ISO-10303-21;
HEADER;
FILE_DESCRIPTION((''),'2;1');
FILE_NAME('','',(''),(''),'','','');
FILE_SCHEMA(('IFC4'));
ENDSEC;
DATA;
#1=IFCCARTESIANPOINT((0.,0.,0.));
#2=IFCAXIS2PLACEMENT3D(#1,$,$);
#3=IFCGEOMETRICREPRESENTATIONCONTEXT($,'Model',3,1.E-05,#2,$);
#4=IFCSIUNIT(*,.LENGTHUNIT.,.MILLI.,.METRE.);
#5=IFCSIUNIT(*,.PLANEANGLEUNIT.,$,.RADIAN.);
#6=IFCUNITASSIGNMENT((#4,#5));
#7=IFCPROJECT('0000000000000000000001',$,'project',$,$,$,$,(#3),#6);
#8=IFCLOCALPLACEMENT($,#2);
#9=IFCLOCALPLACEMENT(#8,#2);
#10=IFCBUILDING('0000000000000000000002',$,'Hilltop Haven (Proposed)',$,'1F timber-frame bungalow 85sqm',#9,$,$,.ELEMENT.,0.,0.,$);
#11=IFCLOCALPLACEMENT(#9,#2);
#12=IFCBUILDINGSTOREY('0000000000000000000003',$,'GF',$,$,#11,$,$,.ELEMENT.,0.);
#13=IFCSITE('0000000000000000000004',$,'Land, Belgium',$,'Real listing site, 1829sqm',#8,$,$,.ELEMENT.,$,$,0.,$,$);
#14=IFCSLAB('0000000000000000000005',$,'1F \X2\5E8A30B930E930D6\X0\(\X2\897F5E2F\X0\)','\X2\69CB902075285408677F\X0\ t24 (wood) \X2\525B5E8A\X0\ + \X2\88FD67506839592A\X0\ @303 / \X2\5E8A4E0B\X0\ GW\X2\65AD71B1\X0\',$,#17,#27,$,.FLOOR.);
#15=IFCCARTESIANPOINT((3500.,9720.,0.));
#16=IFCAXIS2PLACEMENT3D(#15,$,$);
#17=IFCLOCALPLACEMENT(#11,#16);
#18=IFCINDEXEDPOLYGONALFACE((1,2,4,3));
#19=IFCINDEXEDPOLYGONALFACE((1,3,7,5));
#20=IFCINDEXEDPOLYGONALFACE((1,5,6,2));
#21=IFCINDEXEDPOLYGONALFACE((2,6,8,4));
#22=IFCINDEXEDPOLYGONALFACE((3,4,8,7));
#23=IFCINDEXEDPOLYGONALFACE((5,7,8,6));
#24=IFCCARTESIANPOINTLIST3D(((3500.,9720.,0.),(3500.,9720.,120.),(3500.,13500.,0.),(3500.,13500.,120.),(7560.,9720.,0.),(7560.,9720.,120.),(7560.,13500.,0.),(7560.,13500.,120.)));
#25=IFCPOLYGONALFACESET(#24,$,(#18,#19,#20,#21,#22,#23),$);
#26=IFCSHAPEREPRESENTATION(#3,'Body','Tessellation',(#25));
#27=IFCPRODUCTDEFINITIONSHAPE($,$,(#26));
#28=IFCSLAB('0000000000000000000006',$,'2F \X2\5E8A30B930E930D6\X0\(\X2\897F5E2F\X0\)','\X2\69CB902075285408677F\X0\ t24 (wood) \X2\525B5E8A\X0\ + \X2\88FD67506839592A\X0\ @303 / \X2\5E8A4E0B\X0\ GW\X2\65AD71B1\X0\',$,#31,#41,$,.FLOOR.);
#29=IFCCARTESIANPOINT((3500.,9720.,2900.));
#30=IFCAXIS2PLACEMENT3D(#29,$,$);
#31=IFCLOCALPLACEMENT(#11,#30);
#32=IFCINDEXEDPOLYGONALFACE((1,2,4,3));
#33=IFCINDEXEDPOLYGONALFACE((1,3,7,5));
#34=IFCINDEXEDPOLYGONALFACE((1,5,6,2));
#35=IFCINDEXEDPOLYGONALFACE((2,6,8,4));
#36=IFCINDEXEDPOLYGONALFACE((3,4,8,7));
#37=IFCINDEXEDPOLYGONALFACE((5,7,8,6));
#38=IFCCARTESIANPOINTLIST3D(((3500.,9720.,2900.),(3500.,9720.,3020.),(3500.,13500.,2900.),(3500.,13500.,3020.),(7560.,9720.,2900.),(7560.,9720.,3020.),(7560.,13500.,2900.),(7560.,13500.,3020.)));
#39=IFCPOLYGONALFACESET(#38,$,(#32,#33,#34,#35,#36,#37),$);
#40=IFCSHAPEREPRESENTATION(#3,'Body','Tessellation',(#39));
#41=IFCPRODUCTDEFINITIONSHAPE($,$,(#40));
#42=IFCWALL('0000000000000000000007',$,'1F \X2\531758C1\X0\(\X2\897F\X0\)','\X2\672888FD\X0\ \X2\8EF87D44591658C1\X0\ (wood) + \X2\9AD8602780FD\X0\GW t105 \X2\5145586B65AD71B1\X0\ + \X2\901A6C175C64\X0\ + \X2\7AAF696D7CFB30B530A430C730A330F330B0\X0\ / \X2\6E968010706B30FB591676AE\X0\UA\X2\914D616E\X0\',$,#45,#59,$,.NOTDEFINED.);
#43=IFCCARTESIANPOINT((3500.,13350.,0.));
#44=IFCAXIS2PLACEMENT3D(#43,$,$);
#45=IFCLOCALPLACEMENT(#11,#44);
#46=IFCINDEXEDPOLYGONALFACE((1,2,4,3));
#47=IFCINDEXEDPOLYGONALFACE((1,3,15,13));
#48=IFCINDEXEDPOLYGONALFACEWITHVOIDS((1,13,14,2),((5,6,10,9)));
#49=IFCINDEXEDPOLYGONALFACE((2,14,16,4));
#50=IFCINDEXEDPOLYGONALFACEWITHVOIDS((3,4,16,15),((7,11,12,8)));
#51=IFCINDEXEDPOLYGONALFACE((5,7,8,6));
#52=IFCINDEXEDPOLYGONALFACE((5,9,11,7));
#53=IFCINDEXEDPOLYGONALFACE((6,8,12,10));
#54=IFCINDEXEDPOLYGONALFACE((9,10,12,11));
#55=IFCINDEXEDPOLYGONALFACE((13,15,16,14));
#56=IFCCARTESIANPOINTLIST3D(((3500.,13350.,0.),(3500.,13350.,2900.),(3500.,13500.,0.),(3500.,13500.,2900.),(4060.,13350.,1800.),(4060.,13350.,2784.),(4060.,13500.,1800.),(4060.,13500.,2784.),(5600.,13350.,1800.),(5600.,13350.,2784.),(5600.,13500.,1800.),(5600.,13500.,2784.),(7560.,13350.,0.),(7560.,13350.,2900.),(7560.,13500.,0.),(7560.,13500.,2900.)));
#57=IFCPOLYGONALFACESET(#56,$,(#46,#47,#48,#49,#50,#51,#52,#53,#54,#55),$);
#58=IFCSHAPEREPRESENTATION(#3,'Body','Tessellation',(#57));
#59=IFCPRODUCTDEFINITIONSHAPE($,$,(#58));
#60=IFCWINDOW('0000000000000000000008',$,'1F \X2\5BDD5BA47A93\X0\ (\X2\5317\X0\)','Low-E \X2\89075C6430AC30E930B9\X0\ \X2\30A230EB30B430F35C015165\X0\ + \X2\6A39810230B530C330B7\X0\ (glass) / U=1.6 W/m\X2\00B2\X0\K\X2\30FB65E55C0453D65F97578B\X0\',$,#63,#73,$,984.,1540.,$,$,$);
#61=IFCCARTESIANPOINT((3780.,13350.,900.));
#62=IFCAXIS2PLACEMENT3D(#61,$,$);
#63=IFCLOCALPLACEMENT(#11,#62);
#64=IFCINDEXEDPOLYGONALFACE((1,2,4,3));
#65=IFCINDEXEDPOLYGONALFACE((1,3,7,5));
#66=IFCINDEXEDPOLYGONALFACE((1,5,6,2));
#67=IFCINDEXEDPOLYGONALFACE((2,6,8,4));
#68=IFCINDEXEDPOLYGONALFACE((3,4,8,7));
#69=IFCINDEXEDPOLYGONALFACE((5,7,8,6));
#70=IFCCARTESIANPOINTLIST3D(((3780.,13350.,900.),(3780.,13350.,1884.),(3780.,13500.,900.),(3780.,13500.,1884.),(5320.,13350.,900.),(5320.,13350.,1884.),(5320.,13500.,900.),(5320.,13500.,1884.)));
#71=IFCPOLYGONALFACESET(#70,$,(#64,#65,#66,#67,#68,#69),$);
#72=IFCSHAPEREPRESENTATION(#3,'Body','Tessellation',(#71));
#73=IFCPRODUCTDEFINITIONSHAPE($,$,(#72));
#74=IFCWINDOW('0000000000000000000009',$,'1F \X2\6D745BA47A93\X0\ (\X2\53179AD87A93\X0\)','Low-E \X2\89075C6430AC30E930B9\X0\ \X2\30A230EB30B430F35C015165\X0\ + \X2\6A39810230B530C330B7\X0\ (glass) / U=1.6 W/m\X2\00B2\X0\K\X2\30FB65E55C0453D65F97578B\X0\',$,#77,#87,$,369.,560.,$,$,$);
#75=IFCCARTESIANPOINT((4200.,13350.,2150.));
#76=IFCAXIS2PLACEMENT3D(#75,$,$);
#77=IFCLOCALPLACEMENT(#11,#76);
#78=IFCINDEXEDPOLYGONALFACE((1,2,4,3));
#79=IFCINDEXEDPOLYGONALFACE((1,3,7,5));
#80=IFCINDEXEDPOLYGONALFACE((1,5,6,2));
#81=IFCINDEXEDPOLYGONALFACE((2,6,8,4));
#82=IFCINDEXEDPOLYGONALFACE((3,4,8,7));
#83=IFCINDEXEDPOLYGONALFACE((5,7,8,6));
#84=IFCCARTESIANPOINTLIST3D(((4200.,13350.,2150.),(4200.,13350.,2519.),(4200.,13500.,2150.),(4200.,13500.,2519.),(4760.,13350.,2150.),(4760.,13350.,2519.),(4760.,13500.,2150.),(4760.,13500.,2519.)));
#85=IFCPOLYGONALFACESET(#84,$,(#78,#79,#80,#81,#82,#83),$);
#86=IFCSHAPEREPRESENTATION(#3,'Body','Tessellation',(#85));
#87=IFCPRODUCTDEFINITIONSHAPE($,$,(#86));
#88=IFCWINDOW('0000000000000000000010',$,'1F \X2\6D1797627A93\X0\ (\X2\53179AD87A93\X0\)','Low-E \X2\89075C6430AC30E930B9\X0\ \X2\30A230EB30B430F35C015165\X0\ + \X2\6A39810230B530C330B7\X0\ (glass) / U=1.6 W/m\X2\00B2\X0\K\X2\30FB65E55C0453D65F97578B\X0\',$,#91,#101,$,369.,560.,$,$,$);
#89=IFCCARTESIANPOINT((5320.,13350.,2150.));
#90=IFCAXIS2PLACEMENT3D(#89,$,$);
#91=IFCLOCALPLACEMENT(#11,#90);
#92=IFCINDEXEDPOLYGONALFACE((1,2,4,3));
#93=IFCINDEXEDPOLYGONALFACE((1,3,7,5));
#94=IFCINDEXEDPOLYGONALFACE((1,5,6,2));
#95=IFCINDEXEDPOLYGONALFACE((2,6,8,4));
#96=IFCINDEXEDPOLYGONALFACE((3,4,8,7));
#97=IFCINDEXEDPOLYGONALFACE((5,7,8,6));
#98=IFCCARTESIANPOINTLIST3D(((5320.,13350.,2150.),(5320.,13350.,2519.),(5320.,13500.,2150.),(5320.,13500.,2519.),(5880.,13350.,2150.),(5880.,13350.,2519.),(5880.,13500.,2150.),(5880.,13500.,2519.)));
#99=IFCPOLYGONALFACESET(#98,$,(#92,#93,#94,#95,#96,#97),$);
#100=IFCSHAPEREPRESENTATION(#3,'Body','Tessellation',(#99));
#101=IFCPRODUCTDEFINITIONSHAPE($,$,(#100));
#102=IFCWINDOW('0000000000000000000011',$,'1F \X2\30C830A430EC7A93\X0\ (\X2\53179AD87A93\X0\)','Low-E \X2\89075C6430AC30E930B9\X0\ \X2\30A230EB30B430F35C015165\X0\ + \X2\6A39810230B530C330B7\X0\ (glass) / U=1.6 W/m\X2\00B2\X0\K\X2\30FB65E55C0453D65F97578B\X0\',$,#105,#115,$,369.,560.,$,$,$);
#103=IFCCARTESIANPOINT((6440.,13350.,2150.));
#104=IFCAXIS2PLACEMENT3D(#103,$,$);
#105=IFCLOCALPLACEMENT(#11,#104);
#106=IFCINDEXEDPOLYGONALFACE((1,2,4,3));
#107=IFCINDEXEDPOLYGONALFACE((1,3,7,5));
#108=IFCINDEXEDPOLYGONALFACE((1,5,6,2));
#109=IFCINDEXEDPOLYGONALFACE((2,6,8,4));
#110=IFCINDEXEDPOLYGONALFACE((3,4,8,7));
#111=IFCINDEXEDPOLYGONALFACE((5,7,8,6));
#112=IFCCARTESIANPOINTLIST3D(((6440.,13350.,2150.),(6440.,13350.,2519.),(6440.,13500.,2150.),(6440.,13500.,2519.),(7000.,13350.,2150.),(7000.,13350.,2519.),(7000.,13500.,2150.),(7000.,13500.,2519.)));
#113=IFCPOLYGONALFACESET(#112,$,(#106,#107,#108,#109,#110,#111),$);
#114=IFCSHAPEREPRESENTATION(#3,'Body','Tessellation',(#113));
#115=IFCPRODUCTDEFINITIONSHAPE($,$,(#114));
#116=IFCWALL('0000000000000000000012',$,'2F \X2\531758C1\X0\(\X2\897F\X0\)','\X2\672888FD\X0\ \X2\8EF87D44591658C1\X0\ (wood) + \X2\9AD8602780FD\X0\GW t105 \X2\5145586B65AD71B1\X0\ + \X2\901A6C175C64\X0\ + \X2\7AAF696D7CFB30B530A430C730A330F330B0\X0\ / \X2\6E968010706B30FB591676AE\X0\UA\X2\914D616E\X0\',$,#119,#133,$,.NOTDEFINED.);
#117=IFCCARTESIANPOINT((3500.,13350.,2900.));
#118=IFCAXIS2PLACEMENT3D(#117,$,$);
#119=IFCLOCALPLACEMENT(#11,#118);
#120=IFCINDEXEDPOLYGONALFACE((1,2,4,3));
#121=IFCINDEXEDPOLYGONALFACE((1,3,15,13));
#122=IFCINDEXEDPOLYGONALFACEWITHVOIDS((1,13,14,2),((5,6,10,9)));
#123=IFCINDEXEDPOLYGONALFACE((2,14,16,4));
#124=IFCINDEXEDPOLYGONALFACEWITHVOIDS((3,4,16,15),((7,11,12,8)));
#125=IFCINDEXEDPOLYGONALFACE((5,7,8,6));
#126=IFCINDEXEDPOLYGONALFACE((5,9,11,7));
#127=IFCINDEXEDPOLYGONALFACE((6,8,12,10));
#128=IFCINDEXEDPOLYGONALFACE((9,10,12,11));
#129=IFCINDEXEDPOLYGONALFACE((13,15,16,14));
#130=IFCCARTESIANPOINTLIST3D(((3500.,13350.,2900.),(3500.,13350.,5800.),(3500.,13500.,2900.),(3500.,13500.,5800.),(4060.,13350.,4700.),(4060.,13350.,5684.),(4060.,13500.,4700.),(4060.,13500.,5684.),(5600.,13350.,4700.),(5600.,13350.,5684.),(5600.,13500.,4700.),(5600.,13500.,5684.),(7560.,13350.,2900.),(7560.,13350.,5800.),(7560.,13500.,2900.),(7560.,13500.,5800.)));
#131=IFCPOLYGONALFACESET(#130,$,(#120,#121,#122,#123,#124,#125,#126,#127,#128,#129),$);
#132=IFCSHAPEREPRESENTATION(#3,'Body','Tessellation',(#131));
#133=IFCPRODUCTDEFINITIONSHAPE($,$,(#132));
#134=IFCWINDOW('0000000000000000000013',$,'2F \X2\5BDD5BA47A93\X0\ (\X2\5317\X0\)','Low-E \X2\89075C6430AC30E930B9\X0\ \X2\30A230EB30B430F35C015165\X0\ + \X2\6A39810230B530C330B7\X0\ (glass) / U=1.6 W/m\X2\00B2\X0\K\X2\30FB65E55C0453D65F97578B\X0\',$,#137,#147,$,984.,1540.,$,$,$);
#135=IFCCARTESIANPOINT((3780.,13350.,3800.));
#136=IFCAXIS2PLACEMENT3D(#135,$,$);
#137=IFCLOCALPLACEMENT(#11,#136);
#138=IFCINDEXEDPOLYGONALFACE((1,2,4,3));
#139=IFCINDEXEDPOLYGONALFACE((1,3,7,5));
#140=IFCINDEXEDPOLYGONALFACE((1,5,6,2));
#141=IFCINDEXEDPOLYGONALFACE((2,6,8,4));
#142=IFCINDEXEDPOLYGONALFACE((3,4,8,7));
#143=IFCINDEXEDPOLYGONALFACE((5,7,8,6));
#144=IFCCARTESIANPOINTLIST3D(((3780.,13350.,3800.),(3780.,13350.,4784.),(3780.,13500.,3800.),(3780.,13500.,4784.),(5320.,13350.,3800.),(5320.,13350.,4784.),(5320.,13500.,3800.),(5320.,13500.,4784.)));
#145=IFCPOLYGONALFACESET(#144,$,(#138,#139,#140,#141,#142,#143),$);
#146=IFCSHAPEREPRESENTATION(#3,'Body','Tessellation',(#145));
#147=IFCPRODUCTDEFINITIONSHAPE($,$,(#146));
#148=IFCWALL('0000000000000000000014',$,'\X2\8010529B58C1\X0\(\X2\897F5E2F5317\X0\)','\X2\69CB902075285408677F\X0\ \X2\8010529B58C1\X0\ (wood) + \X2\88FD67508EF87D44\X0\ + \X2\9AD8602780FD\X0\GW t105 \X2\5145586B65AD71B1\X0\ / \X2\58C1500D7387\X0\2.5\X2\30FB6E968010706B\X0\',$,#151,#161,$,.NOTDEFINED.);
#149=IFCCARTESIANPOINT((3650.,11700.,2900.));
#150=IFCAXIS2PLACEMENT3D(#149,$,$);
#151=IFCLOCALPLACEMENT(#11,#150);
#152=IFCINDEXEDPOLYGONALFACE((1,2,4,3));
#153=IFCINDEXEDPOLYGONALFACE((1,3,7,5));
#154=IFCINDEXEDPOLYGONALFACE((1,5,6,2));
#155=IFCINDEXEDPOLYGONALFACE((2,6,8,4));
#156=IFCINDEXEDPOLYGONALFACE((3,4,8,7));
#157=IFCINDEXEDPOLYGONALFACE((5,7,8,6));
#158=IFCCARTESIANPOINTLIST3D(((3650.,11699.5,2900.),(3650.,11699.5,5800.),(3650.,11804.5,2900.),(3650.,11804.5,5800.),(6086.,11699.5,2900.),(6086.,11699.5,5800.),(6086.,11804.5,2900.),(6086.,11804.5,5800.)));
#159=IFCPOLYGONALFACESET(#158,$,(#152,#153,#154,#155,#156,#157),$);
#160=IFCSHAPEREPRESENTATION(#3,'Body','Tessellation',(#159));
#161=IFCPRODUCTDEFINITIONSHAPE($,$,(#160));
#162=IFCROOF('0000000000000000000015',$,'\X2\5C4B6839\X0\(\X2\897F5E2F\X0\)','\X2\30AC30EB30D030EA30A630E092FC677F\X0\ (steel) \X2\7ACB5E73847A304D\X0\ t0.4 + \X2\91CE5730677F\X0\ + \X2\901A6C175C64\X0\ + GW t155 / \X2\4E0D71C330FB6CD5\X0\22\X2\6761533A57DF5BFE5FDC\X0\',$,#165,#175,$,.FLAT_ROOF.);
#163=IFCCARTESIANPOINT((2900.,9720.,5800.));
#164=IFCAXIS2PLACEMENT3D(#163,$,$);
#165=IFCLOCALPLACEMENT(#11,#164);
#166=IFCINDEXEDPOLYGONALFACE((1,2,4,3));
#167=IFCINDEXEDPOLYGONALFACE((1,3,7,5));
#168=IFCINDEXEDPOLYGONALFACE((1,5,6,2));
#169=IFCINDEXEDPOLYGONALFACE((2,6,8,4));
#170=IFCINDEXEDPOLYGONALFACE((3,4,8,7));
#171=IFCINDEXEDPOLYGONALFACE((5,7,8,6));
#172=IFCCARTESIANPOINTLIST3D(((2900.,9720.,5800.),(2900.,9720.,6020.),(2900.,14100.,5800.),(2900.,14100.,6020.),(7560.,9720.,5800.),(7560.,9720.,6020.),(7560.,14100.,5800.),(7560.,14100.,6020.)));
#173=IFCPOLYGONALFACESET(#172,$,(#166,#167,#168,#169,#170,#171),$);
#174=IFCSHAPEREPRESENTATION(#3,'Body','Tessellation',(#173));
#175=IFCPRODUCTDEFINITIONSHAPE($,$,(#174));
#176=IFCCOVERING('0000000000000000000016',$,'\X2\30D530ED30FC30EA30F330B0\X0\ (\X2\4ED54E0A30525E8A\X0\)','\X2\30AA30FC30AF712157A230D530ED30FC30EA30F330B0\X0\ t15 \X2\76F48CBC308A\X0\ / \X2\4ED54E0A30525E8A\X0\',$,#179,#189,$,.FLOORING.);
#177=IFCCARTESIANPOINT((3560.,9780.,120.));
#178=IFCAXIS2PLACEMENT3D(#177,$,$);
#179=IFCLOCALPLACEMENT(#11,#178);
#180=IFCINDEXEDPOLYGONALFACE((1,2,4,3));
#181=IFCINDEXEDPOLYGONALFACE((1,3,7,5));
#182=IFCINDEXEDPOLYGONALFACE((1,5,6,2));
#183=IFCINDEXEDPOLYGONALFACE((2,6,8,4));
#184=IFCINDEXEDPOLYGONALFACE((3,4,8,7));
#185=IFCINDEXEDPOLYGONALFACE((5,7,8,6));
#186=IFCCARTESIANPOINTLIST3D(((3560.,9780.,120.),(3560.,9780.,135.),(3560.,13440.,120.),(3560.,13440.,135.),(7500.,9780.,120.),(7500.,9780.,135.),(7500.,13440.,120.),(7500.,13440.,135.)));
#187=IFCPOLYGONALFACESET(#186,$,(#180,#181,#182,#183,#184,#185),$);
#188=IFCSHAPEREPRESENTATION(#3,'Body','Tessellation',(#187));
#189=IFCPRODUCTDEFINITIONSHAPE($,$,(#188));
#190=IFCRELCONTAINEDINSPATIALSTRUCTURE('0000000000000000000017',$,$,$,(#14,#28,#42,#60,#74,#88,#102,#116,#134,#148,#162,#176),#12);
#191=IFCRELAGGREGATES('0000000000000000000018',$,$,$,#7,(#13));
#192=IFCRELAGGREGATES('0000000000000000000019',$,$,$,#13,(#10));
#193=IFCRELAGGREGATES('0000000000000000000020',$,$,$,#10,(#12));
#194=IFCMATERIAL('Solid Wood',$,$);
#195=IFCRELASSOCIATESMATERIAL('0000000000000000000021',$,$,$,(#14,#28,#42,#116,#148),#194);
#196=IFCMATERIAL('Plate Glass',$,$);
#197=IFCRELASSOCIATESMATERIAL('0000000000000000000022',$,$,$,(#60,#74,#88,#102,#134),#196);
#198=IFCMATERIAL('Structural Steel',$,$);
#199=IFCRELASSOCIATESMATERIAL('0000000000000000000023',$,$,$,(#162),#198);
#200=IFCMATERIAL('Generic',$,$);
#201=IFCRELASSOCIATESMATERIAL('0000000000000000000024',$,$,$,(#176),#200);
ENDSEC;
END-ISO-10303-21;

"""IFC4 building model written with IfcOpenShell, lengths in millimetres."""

from ifc_helpers import new_model, si_unit, frame, frame_2d, origin, place, context, project, spatial, rectangle, extrude, material, element, fill, save


model = new_model("IFC4")

# Units and contexts
model_context = context("Model", 3, precision=1e-05, world=origin())
ifc_project = project(units=[si_unit("LENGTHUNIT", "METRE", prefix="MILLI"), si_unit("PLANEANGLEUNIT", "RADIAN")], contexts=[model_context])

# Site, building, storey
site_placement = place(None, origin())
site = spatial("IfcSite", under=ifc_project, at=site_placement, Name="Land, Belgium", ObjectType="Real listing site, 1829sqm", CompositionType="ELEMENT", RefElevation=0.0)
building_placement = place(site_placement, origin())
building = spatial("IfcBuilding", under=site, at=building_placement, Name="Hilltop Haven (Proposed)", ObjectType="1F timber-frame bungalow 85sqm", CompositionType="ELEMENT", ElevationOfRefHeight=0.0, ElevationOfTerrain=0.0)
storey_placement = place(building_placement, origin())
storey = spatial("IfcBuildingStorey", under=building, at=storey_placement, Name="GF", CompositionType="ELEMENT", Elevation=0.0)

# Slabs
ifc_material_1 = material(Name="Solid Wood")
slab_1_placement = place(storey_placement, frame((3500.0, 9720.0, 0.0)))
element("IfcSlab", 1, at=slab_1_placement, inside=storey, material=ifc_material_1, Name="1F 床スラブ(西帯)", Description="構造用合板 t24 (wood) 剛床 + 製材根太 @303 / 床下 GW断熱", PredefinedType="FLOOR", context=model_context, shape_type="SweptSolid", body=[
    extrude(rectangle(XDim=4060.0, YDim=3780.0, at=frame_2d((2030.0, 1890.0))), frame((3500.0, 9720.0, 0.0)), (0.0, 0.0, 1.0), 120.0),
])
slab_2_placement = place(storey_placement, frame((3500.0, 9720.0, 2900.0)))
element("IfcSlab", 2, at=slab_2_placement, inside=storey, material=ifc_material_1, Name="2F 床スラブ(西帯)", Description="構造用合板 t24 (wood) 剛床 + 製材根太 @303 / 床下 GW断熱", PredefinedType="FLOOR", context=model_context, shape_type="SweptSolid", body=[
    extrude(rectangle(XDim=4060.0, YDim=3780.0, at=frame_2d((2030.0, 1890.0))), frame((3500.0, 9720.0, 2900.0)), (0.0, 0.0, 1.0), 120.0),
])

# Wall, openings, windows
wall_1_placement = place(storey_placement, frame((3500.0, 13350.0, 0.0)))
wall_1 = element("IfcWall", 3, at=wall_1_placement, inside=storey, material=ifc_material_1, Name="1F 北壁(西)", Description="木製 軸組外壁 (wood) + 高性能GW t105 充填断熱 + 通気層 + 窯業系サイディング / 準耐火・外皮UA配慮", PredefinedType="NOTDEFINED", context=model_context, shape_type="SweptSolid", body=[
    extrude(rectangle(XDim=4060.0, YDim=150.0, at=frame_2d((2030.0, 75.0))), frame((3500.0, 13350.0, 0.0)), (0.0, 0.0, 1.0), 2900.0),
])
opening_1_placement = place(storey_placement, frame((3780.0, 13350.0, 900.0)))
opening_1 = element("IfcOpeningElement", 4, at=opening_1_placement, cuts=wall_1, PredefinedType="NOTDEFINED", context=model_context, shape_type="SweptSolid", body=[
    extrude(rectangle(XDim=1540.0, YDim=150.0, at=frame_2d((770.0, 75.0))), frame((3780.0, 13350.0, 900.0)), (0.0, 0.0, 1.0), 984.0),
])
opening_2_placement = place(storey_placement, frame((4200.0, 13350.0, 2150.0)))
opening_2 = element("IfcOpeningElement", 5, at=opening_2_placement, cuts=wall_1, PredefinedType="NOTDEFINED", context=model_context, shape_type="SweptSolid", body=[
    extrude(rectangle(XDim=560.0, YDim=150.0, at=frame_2d((280.0, 75.0))), frame((4200.0, 13350.0, 2150.0)), (0.0, 0.0, 1.0), 369.0),
])
opening_3_placement = place(storey_placement, frame((5320.0, 13350.0, 2150.0)))
opening_3 = element("IfcOpeningElement", 6, at=opening_3_placement, cuts=wall_1, PredefinedType="NOTDEFINED", context=model_context, shape_type="SweptSolid", body=[
    extrude(rectangle(XDim=560.0, YDim=150.0, at=frame_2d((280.0, 75.0))), frame((5320.0, 13350.0, 2150.0)), (0.0, 0.0, 1.0), 369.0),
])
opening_4_placement = place(storey_placement, frame((6440.0, 13350.0, 2150.0)))
opening_4 = element("IfcOpeningElement", 7, at=opening_4_placement, cuts=wall_1, PredefinedType="NOTDEFINED", context=model_context, shape_type="SweptSolid", body=[
    extrude(rectangle(XDim=560.0, YDim=150.0, at=frame_2d((280.0, 75.0))), frame((6440.0, 13350.0, 2150.0)), (0.0, 0.0, 1.0), 369.0),
])
ifc_material_2 = material(Name="Plate Glass")
window_1_placement = place(storey_placement, frame((3780.0, 13350.0, 900.0)))
window_1 = element("IfcWindow", 8, at=window_1_placement, inside=storey, material=ifc_material_2, Name="1F 寝室窓 (北)", Description="Low-E 複層ガラス アルゴン封入 + 樹脂サッシ (glass) / U=1.6 W/m²K・日射取得型", OverallHeight=984.0, OverallWidth=1540.0, context=model_context, shape_type="SweptSolid", body=[
    extrude(rectangle(XDim=1540.0, YDim=150.0, at=frame_2d((770.0, 75.0))), frame((3780.0, 13350.0, 900.0)), (0.0, 0.0, 1.0), 984.0),
])
fill(opening_1, window_1)
window_2_placement = place(storey_placement, frame((4200.0, 13350.0, 2150.0)))
window_2 = element("IfcWindow", 9, at=window_2_placement, inside=storey, material=ifc_material_2, Name="1F 浴室窓 (北高窓)", Description="Low-E 複層ガラス アルゴン封入 + 樹脂サッシ (glass) / U=1.6 W/m²K・日射取得型", OverallHeight=369.0, OverallWidth=560.0, context=model_context, shape_type="SweptSolid", body=[
    extrude(rectangle(XDim=560.0, YDim=150.0, at=frame_2d((280.0, 75.0))), frame((4200.0, 13350.0, 2150.0)), (0.0, 0.0, 1.0), 369.0),
])
fill(opening_2, window_2)
window_3_placement = place(storey_placement, frame((5320.0, 13350.0, 2150.0)))
window_3 = element("IfcWindow", 10, at=window_3_placement, inside=storey, material=ifc_material_2, Name="1F 洗面窓 (北高窓)", Description="Low-E 複層ガラス アルゴン封入 + 樹脂サッシ (glass) / U=1.6 W/m²K・日射取得型", OverallHeight=369.0, OverallWidth=560.0, context=model_context, shape_type="SweptSolid", body=[
    extrude(rectangle(XDim=560.0, YDim=150.0, at=frame_2d((280.0, 75.0))), frame((5320.0, 13350.0, 2150.0)), (0.0, 0.0, 1.0), 369.0),
])
fill(opening_3, window_3)
window_4_placement = place(storey_placement, frame((6440.0, 13350.0, 2150.0)))
window_4 = element("IfcWindow", 11, at=window_4_placement, inside=storey, material=ifc_material_2, Name="1F トイレ窓 (北高窓)", Description="Low-E 複層ガラス アルゴン封入 + 樹脂サッシ (glass) / U=1.6 W/m²K・日射取得型", OverallHeight=369.0, OverallWidth=560.0, context=model_context, shape_type="SweptSolid", body=[
    extrude(rectangle(XDim=560.0, YDim=150.0, at=frame_2d((280.0, 75.0))), frame((6440.0, 13350.0, 2150.0)), (0.0, 0.0, 1.0), 369.0),
])
fill(opening_4, window_4)

# Wall, opening, window
wall_2_placement = place(storey_placement, frame((3500.0, 13350.0, 2900.0)))
wall_2 = element("IfcWall", 12, at=wall_2_placement, inside=storey, material=ifc_material_1, Name="2F 北壁(西)", Description="木製 軸組外壁 (wood) + 高性能GW t105 充填断熱 + 通気層 + 窯業系サイディング / 準耐火・外皮UA配慮", PredefinedType="NOTDEFINED", context=model_context, shape_type="SweptSolid", body=[
    extrude(rectangle(XDim=4060.0, YDim=150.0, at=frame_2d((2030.0, 75.0))), frame((3500.0, 13350.0, 2900.0)), (0.0, 0.0, 1.0), 2900.0),
])
opening_5_placement = place(storey_placement, frame((3780.0, 13350.0, 3800.0)))
opening_5 = element("IfcOpeningElement", 13, at=opening_5_placement, cuts=wall_2, PredefinedType="NOTDEFINED", context=model_context, shape_type="SweptSolid", body=[
    extrude(rectangle(XDim=1540.0, YDim=150.0, at=frame_2d((770.0, 75.0))), frame((3780.0, 13350.0, 3800.0)), (0.0, 0.0, 1.0), 984.0),
])
window_5_placement = place(storey_placement, frame((3780.0, 13350.0, 3800.0)))
window_5 = element("IfcWindow", 14, at=window_5_placement, inside=storey, material=ifc_material_2, Name="2F 寝室窓 (北)", Description="Low-E 複層ガラス アルゴン封入 + 樹脂サッシ (glass) / U=1.6 W/m²K・日射取得型", OverallHeight=984.0, OverallWidth=1540.0, context=model_context, shape_type="SweptSolid", body=[
    extrude(rectangle(XDim=1540.0, YDim=150.0, at=frame_2d((770.0, 75.0))), frame((3780.0, 13350.0, 3800.0)), (0.0, 0.0, 1.0), 984.0),
])
fill(opening_5, window_5)

# Wall
wall_3_placement = place(storey_placement, frame((3650.0, 11700.0, 2900.0)))
element("IfcWall", 15, at=wall_3_placement, inside=storey, material=ifc_material_1, Name="耐力壁(西帯北)", Description="構造用合板 耐力壁 (wood) + 製材軸組 + 高性能GW t105 充填断熱 / 壁倍率2.5・準耐火", PredefinedType="NOTDEFINED", context=model_context, shape_type="SweptSolid", body=[
    extrude(rectangle(XDim=2436.0, YDim=105.0, at=frame_2d((1218.0, 52.0))), frame((3650.0, 11700.0, 2900.0)), (0.0, 0.0, 1.0), 2900.0),
])

# Roof
ifc_material_3 = material(Name="Structural Steel")
for number, where, name in (
    (16, (2900.0, 9720.0, 5800.0), "屋根(西帯)"),
):
    element("IfcRoof", number, at=place(storey_placement, frame(where)), inside=storey, material=ifc_material_3, Name=name, Description="ガルバリウム鋼板 (steel) 立平葺き t0.4 + 野地板 + 通気層 + GW t155 / 不燃・法22条区域対応", PredefinedType="FLAT_ROOF", context=model_context, shape_type="SweptSolid", body=[
        extrude(rectangle(XDim=4660.0, YDim=4380.0, at=frame_2d((2330.0, 2190.0))), frame((2900.0, 9720.0, 5800.0)), (0.0, 0.0, 1.0), 220.0),
    ])

# Covering
ifc_material_4 = material(Name="Generic")
covering_1_placement = place(storey_placement, frame((3560.0, 9780.0, 120.0)))
element("IfcCovering", 17, at=covering_1_placement, inside=storey, material=ifc_material_4, Name="フローリング (仕上げ床)", Description="オーク無垢フローリング t15 直貼り / 仕上げ床", PredefinedType="FLOORING", context=model_context, shape_type="SweptSolid", body=[
    extrude(rectangle(XDim=3940.0, YDim=3660.0, at=frame_2d((1970.0, 1830.0))), frame((3560.0, 9780.0, 120.0)), (0.0, 0.0, 1.0), 15.0),
])

save(model, "model.ifc")
